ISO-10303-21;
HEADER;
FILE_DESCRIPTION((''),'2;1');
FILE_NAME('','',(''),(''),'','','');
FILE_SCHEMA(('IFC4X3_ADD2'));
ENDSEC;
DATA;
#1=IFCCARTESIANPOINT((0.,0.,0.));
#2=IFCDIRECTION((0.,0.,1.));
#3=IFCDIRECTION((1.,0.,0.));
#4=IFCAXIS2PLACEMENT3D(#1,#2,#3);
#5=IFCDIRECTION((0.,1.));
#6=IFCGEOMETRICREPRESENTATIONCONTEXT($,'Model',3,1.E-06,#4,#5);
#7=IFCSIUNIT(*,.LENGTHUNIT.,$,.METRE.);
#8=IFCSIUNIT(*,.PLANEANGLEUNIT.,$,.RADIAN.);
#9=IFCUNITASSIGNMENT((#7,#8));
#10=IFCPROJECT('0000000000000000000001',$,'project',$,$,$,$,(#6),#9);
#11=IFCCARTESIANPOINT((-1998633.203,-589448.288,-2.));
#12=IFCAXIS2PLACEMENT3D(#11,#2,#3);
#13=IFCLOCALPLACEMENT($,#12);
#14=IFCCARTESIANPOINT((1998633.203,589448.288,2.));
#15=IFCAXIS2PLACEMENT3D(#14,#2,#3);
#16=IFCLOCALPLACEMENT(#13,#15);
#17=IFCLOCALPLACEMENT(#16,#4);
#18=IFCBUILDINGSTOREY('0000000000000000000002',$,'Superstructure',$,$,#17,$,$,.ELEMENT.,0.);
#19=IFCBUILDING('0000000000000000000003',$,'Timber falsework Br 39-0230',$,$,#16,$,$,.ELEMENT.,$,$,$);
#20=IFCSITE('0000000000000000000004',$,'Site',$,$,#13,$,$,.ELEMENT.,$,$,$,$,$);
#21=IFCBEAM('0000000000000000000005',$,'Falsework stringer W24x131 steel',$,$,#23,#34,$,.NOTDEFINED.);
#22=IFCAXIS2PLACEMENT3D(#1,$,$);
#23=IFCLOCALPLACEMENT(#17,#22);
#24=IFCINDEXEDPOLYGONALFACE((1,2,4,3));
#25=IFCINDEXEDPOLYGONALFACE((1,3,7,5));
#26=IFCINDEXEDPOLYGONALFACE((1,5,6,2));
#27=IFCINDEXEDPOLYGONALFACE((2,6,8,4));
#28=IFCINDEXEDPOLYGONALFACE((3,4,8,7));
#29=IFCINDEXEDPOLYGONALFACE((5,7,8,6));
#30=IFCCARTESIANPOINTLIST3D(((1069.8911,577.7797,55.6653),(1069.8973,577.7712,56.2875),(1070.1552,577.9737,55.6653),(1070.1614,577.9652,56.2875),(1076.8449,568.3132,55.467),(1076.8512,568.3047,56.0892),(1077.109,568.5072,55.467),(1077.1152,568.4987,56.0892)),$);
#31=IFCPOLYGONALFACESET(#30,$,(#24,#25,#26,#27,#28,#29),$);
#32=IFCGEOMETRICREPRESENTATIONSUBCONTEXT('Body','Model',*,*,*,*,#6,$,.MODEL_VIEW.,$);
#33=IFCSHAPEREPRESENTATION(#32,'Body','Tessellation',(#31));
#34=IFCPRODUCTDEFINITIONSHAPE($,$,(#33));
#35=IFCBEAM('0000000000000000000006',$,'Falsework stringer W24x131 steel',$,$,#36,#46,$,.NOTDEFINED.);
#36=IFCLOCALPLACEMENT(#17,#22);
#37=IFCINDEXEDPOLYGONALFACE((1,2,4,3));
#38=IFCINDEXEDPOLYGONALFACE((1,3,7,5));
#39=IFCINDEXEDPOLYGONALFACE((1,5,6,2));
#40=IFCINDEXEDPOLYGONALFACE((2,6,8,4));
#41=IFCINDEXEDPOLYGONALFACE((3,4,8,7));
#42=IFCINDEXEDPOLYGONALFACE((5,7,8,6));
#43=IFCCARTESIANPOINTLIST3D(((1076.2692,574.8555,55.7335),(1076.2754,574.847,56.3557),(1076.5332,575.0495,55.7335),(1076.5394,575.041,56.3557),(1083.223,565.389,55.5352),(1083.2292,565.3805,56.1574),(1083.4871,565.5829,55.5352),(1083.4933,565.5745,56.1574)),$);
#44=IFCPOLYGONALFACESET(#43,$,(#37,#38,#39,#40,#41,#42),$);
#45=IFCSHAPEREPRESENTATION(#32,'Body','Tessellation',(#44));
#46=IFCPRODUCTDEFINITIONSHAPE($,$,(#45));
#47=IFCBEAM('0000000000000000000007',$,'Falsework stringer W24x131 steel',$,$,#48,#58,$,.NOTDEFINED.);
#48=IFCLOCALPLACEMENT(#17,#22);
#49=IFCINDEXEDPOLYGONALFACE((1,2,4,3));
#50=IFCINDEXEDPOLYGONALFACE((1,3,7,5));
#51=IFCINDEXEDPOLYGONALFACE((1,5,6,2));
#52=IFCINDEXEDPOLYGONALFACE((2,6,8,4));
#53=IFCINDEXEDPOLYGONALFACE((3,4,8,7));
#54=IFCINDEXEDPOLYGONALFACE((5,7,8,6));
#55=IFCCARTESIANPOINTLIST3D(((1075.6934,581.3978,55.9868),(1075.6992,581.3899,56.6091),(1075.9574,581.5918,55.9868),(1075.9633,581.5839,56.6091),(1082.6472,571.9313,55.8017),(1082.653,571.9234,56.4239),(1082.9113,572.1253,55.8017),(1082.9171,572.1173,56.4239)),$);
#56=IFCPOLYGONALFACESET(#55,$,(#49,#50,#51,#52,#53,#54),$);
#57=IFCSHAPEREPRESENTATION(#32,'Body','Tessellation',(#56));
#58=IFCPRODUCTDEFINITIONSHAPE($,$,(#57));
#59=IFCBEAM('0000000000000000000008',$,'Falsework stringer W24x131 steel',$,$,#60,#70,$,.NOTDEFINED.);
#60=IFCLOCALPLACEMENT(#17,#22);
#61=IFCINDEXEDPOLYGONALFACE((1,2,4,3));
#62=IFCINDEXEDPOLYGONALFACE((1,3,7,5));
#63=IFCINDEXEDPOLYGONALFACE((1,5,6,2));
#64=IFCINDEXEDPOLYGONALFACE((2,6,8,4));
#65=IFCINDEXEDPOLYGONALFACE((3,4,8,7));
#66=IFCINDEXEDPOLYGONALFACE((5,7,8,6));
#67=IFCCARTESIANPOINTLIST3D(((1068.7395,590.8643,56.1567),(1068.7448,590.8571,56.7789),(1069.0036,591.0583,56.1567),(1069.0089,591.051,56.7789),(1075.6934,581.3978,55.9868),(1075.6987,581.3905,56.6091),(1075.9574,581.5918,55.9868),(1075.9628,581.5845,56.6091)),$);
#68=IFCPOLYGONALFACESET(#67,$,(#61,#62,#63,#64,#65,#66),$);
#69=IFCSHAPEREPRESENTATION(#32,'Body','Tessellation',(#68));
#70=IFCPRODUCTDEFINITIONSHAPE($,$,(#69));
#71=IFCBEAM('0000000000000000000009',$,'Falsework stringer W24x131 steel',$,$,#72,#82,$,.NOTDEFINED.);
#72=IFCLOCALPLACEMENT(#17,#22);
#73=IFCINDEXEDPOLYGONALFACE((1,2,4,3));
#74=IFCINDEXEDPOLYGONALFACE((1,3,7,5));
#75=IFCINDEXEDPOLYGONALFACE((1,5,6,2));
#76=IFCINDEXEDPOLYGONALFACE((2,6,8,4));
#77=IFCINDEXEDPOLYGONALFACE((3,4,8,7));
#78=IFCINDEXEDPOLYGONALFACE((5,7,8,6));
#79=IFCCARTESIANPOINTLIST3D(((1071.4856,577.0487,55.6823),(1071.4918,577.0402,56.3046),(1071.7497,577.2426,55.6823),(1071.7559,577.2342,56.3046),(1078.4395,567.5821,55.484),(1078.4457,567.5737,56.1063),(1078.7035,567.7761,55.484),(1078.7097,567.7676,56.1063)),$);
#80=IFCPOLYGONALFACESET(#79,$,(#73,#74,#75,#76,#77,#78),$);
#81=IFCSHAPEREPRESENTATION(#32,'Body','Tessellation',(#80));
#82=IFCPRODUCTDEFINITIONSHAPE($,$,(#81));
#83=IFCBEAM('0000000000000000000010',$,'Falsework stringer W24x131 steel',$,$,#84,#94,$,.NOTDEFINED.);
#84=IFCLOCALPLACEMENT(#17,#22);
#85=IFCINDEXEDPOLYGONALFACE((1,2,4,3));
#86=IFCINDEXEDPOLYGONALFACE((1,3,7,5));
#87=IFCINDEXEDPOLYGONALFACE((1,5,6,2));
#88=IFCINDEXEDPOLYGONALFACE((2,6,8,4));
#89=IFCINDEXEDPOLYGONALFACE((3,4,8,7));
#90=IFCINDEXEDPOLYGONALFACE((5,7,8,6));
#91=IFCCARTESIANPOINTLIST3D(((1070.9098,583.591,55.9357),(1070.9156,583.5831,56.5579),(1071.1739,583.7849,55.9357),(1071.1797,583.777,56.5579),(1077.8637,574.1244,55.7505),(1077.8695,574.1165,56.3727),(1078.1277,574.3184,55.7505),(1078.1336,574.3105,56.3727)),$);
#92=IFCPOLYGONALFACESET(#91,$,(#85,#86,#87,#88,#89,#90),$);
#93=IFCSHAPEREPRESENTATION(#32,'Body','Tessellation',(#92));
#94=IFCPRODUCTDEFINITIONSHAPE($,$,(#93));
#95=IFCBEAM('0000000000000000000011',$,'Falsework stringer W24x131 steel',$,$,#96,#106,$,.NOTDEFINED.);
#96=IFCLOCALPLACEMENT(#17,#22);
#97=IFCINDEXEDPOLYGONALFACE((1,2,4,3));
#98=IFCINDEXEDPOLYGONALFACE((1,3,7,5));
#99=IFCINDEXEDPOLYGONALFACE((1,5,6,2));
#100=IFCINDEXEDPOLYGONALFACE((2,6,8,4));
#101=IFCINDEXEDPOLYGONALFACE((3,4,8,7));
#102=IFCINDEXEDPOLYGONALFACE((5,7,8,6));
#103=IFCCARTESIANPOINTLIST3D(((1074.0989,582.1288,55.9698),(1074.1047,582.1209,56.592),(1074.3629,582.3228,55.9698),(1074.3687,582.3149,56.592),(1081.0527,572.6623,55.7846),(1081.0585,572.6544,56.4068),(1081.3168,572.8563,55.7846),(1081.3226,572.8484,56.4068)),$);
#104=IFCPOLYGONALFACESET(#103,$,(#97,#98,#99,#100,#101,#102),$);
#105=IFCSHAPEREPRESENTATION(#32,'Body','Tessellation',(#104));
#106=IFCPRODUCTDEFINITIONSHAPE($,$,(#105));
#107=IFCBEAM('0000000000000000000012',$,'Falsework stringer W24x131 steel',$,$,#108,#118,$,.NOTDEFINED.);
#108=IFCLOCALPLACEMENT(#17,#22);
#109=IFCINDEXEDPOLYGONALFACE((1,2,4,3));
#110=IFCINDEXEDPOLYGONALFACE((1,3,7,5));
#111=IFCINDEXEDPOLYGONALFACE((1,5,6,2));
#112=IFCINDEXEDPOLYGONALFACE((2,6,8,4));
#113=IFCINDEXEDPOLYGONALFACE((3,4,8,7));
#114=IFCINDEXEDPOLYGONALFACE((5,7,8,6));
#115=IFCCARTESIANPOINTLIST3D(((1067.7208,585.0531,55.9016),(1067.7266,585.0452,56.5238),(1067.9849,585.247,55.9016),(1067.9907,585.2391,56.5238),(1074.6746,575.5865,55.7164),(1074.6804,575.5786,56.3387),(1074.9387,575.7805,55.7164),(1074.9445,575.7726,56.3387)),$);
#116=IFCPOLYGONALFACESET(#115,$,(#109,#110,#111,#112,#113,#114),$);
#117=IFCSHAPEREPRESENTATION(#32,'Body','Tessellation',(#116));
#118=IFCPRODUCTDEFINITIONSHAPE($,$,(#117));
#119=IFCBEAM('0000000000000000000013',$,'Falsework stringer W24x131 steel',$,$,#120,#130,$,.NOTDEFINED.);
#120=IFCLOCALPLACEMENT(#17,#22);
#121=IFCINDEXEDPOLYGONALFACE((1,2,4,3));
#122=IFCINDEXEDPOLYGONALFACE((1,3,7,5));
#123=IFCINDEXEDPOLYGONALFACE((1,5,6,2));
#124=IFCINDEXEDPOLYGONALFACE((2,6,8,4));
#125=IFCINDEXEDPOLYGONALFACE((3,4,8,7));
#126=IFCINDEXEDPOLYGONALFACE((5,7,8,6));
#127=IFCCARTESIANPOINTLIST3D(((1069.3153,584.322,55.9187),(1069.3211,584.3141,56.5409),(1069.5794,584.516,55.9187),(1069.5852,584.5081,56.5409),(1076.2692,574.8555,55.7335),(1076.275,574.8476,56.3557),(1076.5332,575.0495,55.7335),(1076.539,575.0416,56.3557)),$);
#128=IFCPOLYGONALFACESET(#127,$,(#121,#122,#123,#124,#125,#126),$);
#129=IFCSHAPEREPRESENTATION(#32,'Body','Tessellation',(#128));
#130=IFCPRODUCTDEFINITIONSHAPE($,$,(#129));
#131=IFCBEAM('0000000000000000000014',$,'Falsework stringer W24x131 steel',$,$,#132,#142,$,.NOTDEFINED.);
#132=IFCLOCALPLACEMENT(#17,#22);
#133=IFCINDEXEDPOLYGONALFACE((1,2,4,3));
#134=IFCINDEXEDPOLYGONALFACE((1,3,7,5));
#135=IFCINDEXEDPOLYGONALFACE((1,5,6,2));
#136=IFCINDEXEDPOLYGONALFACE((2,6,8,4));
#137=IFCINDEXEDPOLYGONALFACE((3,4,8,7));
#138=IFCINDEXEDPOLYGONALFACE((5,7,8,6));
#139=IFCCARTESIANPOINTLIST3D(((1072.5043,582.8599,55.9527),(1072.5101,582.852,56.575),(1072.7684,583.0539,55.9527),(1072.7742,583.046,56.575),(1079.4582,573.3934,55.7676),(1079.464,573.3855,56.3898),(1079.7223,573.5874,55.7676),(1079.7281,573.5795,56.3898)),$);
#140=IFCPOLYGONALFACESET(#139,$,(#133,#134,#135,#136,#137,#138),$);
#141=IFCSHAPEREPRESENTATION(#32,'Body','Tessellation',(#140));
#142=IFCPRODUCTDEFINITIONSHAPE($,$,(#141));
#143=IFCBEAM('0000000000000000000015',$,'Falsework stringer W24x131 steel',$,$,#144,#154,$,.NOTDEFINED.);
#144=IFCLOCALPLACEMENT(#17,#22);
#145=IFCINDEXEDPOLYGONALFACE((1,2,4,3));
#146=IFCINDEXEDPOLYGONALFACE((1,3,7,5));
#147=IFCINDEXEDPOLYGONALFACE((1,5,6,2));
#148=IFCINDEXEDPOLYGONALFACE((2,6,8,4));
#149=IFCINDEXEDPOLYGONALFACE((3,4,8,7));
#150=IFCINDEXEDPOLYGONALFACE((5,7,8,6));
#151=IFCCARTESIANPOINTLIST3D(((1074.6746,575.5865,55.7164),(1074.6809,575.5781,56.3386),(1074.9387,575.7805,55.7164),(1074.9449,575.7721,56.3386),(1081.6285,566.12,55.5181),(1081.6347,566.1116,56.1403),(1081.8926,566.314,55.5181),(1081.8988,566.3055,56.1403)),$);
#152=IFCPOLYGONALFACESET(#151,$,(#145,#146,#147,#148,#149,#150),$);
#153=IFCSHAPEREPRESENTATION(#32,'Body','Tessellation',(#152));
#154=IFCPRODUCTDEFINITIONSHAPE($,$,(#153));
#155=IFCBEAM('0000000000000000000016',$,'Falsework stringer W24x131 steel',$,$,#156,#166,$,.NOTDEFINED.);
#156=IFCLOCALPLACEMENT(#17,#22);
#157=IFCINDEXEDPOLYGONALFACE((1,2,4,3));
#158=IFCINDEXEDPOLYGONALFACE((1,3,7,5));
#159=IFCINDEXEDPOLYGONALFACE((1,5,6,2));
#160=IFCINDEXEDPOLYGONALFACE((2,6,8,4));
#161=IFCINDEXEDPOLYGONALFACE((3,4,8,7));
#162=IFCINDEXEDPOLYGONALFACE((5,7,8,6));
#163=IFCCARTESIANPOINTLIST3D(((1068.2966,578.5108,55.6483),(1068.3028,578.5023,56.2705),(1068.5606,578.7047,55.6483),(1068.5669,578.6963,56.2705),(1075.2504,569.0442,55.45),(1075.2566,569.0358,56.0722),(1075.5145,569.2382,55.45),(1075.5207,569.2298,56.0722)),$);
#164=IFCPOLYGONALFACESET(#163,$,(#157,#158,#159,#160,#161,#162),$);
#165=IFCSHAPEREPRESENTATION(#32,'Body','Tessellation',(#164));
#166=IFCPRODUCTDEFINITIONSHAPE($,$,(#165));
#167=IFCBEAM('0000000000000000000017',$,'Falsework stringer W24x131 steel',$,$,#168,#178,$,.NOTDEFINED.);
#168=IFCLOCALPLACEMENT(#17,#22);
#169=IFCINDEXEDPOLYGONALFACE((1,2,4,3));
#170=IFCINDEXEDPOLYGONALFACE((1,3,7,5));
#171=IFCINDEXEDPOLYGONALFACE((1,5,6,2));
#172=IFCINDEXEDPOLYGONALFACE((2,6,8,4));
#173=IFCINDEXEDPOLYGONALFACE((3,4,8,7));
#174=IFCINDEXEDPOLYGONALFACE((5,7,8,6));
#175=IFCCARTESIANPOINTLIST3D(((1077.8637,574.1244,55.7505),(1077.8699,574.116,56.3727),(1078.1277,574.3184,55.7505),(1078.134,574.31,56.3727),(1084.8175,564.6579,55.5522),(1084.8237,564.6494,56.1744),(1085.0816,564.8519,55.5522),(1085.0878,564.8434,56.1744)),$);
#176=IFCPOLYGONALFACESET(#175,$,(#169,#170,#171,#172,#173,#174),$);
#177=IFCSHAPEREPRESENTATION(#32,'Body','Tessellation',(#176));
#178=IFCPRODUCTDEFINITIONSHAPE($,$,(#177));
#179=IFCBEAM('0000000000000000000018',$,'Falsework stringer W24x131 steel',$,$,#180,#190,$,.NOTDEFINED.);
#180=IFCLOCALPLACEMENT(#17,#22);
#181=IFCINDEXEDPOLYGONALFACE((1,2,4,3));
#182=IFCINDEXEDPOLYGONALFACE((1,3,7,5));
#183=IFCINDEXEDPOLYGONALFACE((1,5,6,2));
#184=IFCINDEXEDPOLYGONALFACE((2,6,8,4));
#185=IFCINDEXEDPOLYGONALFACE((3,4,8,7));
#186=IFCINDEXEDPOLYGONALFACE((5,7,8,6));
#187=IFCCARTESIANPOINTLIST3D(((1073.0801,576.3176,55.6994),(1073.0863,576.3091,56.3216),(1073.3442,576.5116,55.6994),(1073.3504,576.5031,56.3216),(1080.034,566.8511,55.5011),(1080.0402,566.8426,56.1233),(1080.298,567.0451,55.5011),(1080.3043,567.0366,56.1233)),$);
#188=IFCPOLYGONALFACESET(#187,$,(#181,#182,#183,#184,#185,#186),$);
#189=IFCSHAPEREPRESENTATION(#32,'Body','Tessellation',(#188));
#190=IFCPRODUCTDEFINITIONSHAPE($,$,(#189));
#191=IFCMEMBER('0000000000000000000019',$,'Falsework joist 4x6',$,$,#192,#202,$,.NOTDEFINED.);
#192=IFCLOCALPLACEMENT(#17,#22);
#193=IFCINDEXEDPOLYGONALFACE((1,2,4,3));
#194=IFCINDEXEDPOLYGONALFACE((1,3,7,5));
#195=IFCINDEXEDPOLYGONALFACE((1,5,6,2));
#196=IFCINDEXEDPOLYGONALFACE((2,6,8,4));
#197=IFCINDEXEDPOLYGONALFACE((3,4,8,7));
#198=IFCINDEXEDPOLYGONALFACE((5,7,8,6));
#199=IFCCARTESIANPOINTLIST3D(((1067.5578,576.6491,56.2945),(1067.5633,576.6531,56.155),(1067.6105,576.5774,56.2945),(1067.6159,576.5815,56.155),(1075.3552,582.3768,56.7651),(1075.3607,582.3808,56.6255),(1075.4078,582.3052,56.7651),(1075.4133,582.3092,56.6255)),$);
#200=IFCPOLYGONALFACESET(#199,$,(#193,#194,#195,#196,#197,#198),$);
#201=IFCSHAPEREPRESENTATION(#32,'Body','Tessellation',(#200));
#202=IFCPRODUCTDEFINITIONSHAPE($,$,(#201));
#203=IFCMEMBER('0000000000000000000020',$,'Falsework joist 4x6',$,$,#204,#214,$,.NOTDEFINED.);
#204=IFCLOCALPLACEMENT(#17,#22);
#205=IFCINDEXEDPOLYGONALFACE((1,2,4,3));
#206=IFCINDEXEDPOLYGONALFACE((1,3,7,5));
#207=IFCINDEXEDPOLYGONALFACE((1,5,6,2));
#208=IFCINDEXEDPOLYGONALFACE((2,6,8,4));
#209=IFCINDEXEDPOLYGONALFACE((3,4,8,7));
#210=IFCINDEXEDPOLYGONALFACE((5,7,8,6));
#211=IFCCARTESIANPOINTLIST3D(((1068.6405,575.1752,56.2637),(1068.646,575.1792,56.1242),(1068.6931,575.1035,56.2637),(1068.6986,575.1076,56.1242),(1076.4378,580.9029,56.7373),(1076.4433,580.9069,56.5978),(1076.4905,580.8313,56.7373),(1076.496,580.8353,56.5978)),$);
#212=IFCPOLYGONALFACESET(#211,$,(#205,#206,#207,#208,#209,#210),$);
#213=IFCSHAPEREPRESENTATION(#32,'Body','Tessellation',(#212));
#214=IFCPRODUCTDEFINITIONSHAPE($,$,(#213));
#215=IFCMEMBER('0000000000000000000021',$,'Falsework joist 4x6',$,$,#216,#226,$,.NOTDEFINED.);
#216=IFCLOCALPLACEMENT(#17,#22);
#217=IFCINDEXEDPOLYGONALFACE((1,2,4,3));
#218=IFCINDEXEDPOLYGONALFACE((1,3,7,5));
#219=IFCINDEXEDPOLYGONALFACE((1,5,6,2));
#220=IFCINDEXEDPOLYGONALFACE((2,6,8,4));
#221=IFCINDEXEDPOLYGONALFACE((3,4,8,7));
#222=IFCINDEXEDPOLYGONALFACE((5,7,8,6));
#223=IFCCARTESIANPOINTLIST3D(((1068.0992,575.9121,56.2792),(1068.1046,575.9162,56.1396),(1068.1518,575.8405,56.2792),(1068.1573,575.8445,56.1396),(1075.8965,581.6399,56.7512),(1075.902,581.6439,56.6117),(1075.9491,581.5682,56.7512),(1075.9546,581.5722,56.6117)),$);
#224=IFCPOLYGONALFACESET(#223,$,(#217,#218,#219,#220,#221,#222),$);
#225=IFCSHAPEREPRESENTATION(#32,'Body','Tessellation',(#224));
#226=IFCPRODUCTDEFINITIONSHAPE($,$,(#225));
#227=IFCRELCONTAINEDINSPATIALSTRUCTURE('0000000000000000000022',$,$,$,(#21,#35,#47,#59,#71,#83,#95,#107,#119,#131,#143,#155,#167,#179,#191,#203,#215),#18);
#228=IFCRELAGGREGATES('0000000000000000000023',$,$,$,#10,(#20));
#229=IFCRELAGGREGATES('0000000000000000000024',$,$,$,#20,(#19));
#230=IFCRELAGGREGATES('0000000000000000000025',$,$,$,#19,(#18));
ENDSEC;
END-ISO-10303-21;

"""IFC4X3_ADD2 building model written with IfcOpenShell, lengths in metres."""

from ifc_helpers import new_model, si_unit, direction, frame, frame_2d, origin, origin_with_axes, place, context, subcontext, project, spatial, rectangle, extrude, element, save


model = new_model("IFC4X3_ADD2")

# Units and contexts
model_context = context("Model", 3, precision=1e-06, world=origin_with_axes(), true_north=direction((0.0, 1.0)))
body_context = subcontext(model_context, "Body", "Model", "MODEL_VIEW")
ifc_project = project(units=[si_unit("LENGTHUNIT", "METRE"), si_unit("PLANEANGLEUNIT", "RADIAN")], contexts=[model_context])

# Site, building, storey
site_placement = place(None, frame((-1998633.203, -589448.288, -2.0), z_axis=(0.0, 0.0, 1.0), x_axis=(1.0, 0.0, 0.0)))
site = spatial("IfcSite", under=ifc_project, at=site_placement, Name="Site", CompositionType="ELEMENT")
building_placement = place(site_placement, frame((1998633.203, 589448.288, 2.0), z_axis=(0.0, 0.0, 1.0), x_axis=(1.0, 0.0, 0.0)))
building = spatial("IfcBuilding", under=site, at=building_placement, Name="Timber falsework Br 39-0230", CompositionType="ELEMENT")
storey_placement = place(building_placement, origin_with_axes())
storey = spatial("IfcBuildingStorey", under=building, at=storey_placement, Name="Superstructure", CompositionType="ELEMENT", Elevation=0.0)

# Beams
for number, where, z_axis, x_axis, name in (
    (1, (1070.0231, 577.8767, 55.6653), (0.591929, -0.805813, -0.016879), (0.805928, 0.592013, 0.0), "Falsework stringer W24x131 steel"),
    (2, (1076.4012, 574.9525, 55.7335), (0.591929, -0.805813, -0.016879), (0.805928, 0.592013, 0.0), "Falsework stringer W24x131 steel"),
):
    element("IfcBeam", number, at=place(storey_placement, frame(where, z_axis=z_axis, x_axis=x_axis)), inside=storey, Name=name, PredefinedType="NOTDEFINED", context=body_context, shape_type="SweptSolid", body=[
        extrude(rectangle(XDim=0.3277, YDim=0.6223, at=frame_2d((0.0, 0.3111))), origin(), (0.0, 0.0, 1.0), 11.7478),
    ])
beam_1_placement = place(storey_placement, frame((1075.8254, 581.4948, 55.9868), z_axis=(0.59194, -0.805828, -0.015763), x_axis=(0.805928, 0.592013, 0.0)))
element("IfcBeam", 3, at=beam_1_placement, inside=storey, Name="Falsework stringer W24x131 steel", PredefinedType="NOTDEFINED", context=body_context, shape_type="SweptSolid", body=[
    extrude(rectangle(XDim=0.3277, YDim=0.6223, at=frame_2d((0.0, 0.3111))), origin(), (0.0, 0.0, 1.0), 11.7476),
])
beam_2_placement = place(storey_placement, frame((1068.8716, 590.9613, 56.1567), z_axis=(0.591951, -0.805844, -0.01446), x_axis=(0.805928, 0.592013, 0.0)))
element("IfcBeam", 4, at=beam_2_placement, inside=storey, Name="Falsework stringer W24x131 steel", PredefinedType="NOTDEFINED", context=body_context, shape_type="SweptSolid", body=[
    extrude(rectangle(XDim=0.3277, YDim=0.6223, at=frame_2d((0.0, 0.3111))), origin(), (0.0, 0.0, 1.0), 11.7473),
])
beam_3_placement = place(storey_placement, frame((1071.6176, 577.1456, 55.6823), z_axis=(0.591929, -0.805813, -0.016879), x_axis=(0.805928, 0.592013, 0.0)))
element("IfcBeam", 5, at=beam_3_placement, inside=storey, Name="Falsework stringer W24x131 steel", PredefinedType="NOTDEFINED", context=body_context, shape_type="SweptSolid", body=[
    extrude(rectangle(XDim=0.3277, YDim=0.6223, at=frame_2d((0.0, 0.3111))), origin(), (0.0, 0.0, 1.0), 11.7478),
])
for number, where, z_axis, x_axis, name in (
    (6, (1071.0419, 583.6879, 55.9357), (0.59194, -0.805828, -0.015763), (0.805928, 0.592013, 0.0), "Falsework stringer W24x131 steel"),
    (7, (1074.2309, 582.2258, 55.9698), (0.59194, -0.805828, -0.015763), (0.805928, 0.592013, 0.0), "Falsework stringer W24x131 steel"),
    (8, (1067.8528, 585.1501, 55.9016), (0.59194, -0.805828, -0.015763), (0.805928, 0.592013, 0.0), "Falsework stringer W24x131 steel"),
    (9, (1069.4473, 584.419, 55.9187), (0.59194, -0.805828, -0.015763), (0.805928, 0.592013, 0.0), "Falsework stringer W24x131 steel"),
    (10, (1072.6364, 582.9569, 55.9527), (0.59194, -0.805828, -0.015763), (0.805928, 0.592013, 0.0), "Falsework stringer W24x131 steel"),
):
    element("IfcBeam", number, at=place(storey_placement, frame(where, z_axis=z_axis, x_axis=x_axis)), inside=storey, Name=name, PredefinedType="NOTDEFINED", context=body_context, shape_type="SweptSolid", body=[
        extrude(rectangle(XDim=0.3277, YDim=0.6223, at=frame_2d((0.0, 0.3111))), origin(), (0.0, 0.0, 1.0), 11.7476),
    ])
beam_4_placement = place(storey_placement, frame((1074.8067, 575.6835, 55.7164), z_axis=(0.591929, -0.805813, -0.016879), x_axis=(0.805928, 0.592013, 0.0)))
element("IfcBeam", 11, at=beam_4_placement, inside=storey, Name="Falsework stringer W24x131 steel", PredefinedType="NOTDEFINED", context=body_context, shape_type="SweptSolid", body=[
    extrude(rectangle(XDim=0.3277, YDim=0.6223, at=frame_2d((0.0, 0.3111))), origin(), (0.0, 0.0, 1.0), 11.7478),
])
for number, where, z_axis, x_axis, name in (
    (12, (1068.4286, 578.6078, 55.6483), (0.591929, -0.805813, -0.016879), (0.805928, 0.592013, 0.0), "Falsework stringer W24x131 steel"),
    (13, (1077.9957, 574.2214, 55.7505), (0.591929, -0.805813, -0.016879), (0.805928, 0.592013, 0.0), "Falsework stringer W24x131 steel"),
    (14, (1073.2122, 576.4146, 55.6994), (0.591929, -0.805813, -0.016879), (0.805928, 0.592013, 0.0), "Falsework stringer W24x131 steel"),
):
    element("IfcBeam", number, at=place(storey_placement, frame(where, z_axis=z_axis, x_axis=x_axis)), inside=storey, Name=name, PredefinedType="NOTDEFINED", context=body_context, shape_type="SweptSolid", body=[
        extrude(rectangle(XDim=0.3277, YDim=0.6223, at=frame_2d((0.0, 0.3111))), origin(), (0.0, 0.0, 1.0), 11.7478),
    ])

# Members
member_1_placement = place(storey_placement, frame((1067.5896, 576.6173, 56.155), z_axis=(0.804977, 0.591314, 0.048579), x_axis=(-0.592013, 0.805928, 0.0)))
element("IfcMember", 15, at=member_1_placement, inside=storey, Name="Falsework joist 4x6", PredefinedType="NOTDEFINED", context=body_context, shape_type="SweptSolid", body=[
    extrude(rectangle(XDim=0.0889, YDim=0.1397, at=frame_2d((0.0, 0.0698))), origin(), (0.0, 0.0, 1.0), 9.6864),
])
member_2_placement = place(storey_placement, frame((1068.6723, 575.1434, 56.1242), z_axis=(0.804965, 0.591305, 0.04889), x_axis=(-0.592013, 0.805928, 0.0)))
element("IfcMember", 16, at=member_2_placement, inside=storey, Name="Falsework joist 4x6", PredefinedType="NOTDEFINED", context=body_context, shape_type="SweptSolid", body=[
    extrude(rectangle(XDim=0.0889, YDim=0.1397, at=frame_2d((0.0, 0.0698))), origin(), (0.0, 0.0, 1.0), 9.6866),
])
member_3_placement = place(storey_placement, frame((1068.131, 575.8803, 56.1396), z_axis=(0.804971, 0.59131, 0.048735), x_axis=(-0.592013, 0.805928, 0.0)))
element("IfcMember", 17, at=member_3_placement, inside=storey, Name="Falsework joist 4x6", PredefinedType="NOTDEFINED", context=body_context, shape_type="SweptSolid", body=[
    extrude(rectangle(XDim=0.0889, YDim=0.1397, at=frame_2d((0.0, 0.0698))), origin(), (0.0, 0.0, 1.0), 9.6865),
])

save(model, "model.ifc")
